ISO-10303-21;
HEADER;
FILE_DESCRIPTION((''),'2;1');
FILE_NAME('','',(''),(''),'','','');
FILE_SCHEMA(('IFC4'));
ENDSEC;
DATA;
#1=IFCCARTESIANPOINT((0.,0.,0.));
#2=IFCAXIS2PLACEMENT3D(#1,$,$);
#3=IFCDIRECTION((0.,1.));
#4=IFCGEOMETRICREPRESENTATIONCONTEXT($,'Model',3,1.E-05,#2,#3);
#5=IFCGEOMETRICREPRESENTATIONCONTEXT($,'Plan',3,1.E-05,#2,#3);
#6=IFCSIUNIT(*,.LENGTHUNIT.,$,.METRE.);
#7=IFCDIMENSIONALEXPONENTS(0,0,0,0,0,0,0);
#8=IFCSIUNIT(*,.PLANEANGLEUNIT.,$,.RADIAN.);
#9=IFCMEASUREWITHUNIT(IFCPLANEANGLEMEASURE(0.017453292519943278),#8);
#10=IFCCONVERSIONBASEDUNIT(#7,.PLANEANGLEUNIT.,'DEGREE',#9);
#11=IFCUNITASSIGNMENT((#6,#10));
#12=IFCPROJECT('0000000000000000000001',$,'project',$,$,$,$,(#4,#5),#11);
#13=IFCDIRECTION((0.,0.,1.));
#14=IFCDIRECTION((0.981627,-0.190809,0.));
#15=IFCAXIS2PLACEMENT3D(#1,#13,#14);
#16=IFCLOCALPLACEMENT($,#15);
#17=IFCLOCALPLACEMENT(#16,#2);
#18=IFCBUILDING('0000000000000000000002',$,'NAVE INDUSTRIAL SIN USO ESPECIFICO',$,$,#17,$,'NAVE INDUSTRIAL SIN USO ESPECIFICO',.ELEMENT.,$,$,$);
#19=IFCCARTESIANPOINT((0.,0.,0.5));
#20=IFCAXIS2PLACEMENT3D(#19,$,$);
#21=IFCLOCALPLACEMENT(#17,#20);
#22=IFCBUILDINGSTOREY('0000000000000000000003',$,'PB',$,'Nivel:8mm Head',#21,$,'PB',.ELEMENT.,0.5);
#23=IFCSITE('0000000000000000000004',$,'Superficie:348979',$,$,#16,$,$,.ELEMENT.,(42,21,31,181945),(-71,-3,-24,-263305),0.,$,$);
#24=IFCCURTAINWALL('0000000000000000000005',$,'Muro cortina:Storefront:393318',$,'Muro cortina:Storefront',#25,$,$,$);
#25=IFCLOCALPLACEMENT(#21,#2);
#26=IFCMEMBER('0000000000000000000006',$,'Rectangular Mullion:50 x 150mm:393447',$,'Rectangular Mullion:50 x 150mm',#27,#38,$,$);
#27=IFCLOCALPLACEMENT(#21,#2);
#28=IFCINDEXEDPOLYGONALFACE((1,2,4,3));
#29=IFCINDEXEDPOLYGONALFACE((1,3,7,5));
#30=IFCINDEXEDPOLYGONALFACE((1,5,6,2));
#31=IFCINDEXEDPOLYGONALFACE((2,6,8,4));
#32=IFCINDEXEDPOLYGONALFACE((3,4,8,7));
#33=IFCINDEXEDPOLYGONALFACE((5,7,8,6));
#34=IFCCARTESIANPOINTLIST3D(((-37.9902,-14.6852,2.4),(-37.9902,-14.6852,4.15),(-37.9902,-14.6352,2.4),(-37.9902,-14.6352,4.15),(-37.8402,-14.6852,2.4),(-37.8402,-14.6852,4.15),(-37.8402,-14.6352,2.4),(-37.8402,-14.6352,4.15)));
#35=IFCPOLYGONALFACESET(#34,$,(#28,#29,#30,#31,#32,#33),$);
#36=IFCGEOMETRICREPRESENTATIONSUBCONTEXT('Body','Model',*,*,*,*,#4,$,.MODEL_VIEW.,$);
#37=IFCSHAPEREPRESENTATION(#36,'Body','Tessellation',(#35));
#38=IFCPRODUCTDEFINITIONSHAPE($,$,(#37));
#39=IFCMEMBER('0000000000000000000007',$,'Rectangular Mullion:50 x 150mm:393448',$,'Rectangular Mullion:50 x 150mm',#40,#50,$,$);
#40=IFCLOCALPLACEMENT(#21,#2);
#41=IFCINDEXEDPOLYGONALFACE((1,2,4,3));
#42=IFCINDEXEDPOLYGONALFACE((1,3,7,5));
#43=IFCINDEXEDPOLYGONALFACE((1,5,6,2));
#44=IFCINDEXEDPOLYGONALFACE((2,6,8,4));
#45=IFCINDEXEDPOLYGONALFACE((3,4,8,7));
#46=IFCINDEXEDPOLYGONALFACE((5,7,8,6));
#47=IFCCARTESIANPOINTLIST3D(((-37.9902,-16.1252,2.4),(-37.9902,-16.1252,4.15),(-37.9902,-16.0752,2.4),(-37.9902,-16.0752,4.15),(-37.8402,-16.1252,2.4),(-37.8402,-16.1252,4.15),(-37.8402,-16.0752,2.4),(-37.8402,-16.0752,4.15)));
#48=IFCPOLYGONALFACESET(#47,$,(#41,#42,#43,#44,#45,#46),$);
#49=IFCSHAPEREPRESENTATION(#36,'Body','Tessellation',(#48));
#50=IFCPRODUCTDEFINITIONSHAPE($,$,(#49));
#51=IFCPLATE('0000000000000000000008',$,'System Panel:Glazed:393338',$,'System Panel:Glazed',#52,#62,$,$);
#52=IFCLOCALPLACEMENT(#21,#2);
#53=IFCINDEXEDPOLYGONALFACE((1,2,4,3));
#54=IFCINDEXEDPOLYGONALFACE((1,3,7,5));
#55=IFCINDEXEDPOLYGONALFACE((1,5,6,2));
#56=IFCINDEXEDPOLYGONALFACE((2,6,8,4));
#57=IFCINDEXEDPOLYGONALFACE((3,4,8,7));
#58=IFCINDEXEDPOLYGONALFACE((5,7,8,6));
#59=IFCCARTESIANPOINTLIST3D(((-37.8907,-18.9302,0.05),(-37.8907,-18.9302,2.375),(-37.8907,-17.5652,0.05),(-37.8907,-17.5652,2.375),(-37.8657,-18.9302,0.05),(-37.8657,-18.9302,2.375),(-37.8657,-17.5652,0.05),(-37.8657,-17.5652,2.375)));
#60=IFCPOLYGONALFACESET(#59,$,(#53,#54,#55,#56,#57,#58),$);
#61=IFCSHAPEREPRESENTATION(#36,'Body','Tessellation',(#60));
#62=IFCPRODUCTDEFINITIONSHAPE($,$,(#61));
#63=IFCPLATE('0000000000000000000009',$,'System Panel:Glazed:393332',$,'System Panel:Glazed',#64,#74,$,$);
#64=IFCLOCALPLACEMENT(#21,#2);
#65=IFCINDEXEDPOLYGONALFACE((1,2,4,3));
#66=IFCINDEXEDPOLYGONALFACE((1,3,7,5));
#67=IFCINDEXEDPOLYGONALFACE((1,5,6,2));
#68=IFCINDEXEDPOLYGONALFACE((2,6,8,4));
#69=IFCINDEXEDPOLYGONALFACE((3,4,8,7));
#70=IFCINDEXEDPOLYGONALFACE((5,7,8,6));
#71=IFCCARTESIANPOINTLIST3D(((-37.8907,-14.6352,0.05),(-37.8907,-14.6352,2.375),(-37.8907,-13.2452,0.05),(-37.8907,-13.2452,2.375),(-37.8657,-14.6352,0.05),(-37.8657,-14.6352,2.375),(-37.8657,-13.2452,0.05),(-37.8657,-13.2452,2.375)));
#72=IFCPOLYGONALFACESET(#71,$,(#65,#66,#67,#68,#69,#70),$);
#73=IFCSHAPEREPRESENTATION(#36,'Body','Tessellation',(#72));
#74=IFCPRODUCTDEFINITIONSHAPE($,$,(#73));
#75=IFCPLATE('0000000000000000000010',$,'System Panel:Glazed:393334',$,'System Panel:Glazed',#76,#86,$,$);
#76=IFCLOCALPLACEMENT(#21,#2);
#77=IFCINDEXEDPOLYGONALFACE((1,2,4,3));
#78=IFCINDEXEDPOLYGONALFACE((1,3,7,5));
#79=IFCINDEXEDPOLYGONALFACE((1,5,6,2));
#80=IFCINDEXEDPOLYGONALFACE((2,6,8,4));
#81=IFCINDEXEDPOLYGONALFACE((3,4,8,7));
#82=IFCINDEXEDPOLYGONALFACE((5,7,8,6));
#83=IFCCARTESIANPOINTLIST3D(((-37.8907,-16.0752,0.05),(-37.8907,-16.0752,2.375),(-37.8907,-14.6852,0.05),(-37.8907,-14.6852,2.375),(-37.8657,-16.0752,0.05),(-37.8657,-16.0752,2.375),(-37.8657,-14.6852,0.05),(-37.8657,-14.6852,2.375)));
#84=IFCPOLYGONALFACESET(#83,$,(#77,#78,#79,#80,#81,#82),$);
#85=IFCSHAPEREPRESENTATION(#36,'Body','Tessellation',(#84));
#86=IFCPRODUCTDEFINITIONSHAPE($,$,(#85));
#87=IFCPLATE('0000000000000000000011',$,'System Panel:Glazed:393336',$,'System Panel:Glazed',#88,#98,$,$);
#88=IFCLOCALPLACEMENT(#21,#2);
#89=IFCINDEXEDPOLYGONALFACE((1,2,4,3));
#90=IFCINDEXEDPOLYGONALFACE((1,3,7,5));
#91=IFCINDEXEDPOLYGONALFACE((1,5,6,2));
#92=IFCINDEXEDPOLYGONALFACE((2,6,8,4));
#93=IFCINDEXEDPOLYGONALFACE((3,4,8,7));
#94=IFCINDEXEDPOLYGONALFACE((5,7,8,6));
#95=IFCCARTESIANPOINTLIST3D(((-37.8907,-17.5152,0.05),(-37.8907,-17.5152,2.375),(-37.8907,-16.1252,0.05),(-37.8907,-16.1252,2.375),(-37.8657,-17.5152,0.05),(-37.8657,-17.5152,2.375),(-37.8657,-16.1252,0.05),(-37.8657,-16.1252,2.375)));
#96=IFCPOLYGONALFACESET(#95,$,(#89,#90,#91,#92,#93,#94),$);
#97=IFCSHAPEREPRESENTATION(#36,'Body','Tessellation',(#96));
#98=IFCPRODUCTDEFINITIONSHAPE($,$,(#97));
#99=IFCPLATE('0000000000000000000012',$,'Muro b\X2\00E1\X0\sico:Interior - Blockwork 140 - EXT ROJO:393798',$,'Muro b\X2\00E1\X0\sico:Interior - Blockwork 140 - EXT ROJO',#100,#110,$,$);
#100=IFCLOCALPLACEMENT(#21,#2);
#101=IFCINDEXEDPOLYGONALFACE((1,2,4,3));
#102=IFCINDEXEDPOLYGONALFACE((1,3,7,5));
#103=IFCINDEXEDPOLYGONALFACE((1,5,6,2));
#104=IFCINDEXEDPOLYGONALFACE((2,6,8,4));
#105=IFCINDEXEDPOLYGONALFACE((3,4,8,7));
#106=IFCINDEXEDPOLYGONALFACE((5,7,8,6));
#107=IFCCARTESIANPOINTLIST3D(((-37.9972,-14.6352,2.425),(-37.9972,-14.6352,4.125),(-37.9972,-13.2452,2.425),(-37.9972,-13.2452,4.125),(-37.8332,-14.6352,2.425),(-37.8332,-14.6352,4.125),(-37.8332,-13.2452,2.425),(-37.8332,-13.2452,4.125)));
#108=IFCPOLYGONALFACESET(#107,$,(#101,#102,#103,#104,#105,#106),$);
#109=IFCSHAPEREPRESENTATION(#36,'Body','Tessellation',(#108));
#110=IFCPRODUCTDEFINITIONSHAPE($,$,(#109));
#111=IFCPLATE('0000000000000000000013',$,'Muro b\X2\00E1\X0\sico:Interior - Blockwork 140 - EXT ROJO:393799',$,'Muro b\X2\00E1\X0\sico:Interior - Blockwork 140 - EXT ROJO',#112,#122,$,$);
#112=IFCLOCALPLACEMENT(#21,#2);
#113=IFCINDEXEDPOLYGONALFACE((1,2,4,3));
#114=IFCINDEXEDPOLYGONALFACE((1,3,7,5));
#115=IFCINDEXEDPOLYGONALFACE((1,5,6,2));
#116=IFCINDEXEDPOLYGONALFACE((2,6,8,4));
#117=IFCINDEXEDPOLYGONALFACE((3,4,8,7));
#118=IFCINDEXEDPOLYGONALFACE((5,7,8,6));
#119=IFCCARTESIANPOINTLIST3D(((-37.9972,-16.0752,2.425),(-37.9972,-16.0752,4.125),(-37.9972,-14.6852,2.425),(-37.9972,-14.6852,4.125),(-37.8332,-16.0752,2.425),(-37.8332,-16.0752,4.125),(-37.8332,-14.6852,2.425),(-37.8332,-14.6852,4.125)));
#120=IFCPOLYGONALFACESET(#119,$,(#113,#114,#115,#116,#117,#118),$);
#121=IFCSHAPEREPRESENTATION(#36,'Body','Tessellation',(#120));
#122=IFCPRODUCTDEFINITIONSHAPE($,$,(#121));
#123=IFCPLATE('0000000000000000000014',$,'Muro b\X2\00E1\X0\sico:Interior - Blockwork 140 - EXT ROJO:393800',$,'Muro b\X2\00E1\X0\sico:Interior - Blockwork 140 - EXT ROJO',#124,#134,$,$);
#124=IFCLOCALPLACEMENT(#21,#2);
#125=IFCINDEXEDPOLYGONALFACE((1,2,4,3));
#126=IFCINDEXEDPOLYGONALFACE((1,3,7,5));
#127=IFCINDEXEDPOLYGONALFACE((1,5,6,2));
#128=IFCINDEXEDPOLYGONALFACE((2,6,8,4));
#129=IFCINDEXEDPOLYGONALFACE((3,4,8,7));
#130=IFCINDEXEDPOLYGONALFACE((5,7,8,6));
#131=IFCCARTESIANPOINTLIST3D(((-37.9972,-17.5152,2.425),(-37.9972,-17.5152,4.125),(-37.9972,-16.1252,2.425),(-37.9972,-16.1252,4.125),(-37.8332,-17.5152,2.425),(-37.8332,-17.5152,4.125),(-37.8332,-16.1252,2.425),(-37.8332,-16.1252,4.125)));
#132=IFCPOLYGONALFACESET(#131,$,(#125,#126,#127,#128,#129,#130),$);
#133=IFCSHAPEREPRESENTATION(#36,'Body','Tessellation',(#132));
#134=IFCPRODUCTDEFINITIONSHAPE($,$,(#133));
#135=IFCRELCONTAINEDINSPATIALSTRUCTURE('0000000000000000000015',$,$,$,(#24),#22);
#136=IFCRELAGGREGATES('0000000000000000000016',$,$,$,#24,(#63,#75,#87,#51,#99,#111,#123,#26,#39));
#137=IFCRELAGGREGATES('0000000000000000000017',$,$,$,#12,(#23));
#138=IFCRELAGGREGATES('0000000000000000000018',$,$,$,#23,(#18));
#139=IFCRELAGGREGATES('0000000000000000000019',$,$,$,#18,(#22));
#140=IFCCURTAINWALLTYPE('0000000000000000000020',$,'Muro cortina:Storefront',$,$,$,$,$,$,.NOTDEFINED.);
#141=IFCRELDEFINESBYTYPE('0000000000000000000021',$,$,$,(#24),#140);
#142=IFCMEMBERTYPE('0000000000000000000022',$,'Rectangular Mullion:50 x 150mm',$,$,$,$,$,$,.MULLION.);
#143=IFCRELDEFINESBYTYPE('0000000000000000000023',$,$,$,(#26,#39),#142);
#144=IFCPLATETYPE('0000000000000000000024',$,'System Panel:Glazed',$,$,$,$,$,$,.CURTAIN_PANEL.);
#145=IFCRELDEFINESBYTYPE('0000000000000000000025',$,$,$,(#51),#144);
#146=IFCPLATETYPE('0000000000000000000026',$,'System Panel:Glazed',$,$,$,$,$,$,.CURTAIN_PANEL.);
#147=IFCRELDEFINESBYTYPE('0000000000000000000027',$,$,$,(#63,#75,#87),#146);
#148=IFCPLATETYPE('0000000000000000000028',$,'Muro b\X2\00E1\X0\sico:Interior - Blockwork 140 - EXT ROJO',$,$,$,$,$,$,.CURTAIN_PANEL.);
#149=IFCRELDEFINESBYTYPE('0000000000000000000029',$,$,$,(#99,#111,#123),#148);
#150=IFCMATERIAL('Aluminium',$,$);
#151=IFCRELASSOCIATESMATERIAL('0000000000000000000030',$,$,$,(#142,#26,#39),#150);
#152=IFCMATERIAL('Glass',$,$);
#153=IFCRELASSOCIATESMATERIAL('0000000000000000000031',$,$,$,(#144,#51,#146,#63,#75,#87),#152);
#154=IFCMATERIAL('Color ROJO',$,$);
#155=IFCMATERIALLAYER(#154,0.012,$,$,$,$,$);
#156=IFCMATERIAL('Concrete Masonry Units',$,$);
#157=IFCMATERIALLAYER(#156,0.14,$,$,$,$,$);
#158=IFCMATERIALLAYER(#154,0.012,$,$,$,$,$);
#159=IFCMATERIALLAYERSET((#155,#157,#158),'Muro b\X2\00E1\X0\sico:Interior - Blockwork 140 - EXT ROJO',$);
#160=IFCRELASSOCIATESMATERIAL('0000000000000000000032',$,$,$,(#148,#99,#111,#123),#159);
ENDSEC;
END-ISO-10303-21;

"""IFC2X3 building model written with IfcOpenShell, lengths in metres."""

from ifc_helpers import new_model, entity, si_unit, converted_unit, direction, frame, frame_2d, origin, origin_2d_with_axis, place, context, subcontext, project, spatial, rectangle, extrude, source, transform, mapped, material, layer, layer_set, layer_usage, type_object, type_shapes, element, aggregate, save


model = new_model("IFC2X3")

# Units and contexts
model_context = context("Model", 3, precision=1e-05, world=origin(), true_north=direction((0.0, 1.0)))
plan_context = context("Plan", 3, precision=1e-05, world=origin(), true_north=direction((0.0, 1.0)))
body_context = subcontext(model_context, "Body", "Model", "MODEL_VIEW")
ifc_project = project(units=[si_unit("LENGTHUNIT", "METRE"), converted_unit("PLANEANGLEUNIT", "DEGREE", entity("IfcPlaneAngleMeasure", 0.017453292519943278), si_unit("PLANEANGLEUNIT", "RADIAN"), dimensions=[0, 0, 0, 0, 0, 0, 0])], contexts=[model_context, plan_context])

# Site, building, storey
site_placement = place(None, frame((0.0, 0.0, 0.0), z_axis=(0.0, 0.0, 1.0), x_axis=(0.981627, -0.190809, 0.0)))
site = spatial("IfcSite", under=ifc_project, at=site_placement, Name="Superficie:348979", CompositionType="ELEMENT", RefLatitude=(42, 21, 31, 181945), RefLongitude=(-71, -3, -24, -263305), RefElevation=0.0)
building_placement = place(site_placement, origin())
building = spatial("IfcBuilding", under=site, at=building_placement, Name="NAVE INDUSTRIAL SIN USO ESPECIFICO", LongName="NAVE INDUSTRIAL SIN USO ESPECIFICO", CompositionType="ELEMENT")
storey_placement = place(building_placement, frame((0.0, 0.0, 0.5)))
storey = spatial("IfcBuildingStorey", under=building, at=storey_placement, Name="PB", ObjectType="Nivel:8mm Head", LongName="PB", CompositionType="ELEMENT", Elevation=0.5)

# Curtain wall, members, plates
curtain_wall_type = type_object("IfcCurtainWallType", Name="Muro cortina:Storefront", PredefinedType="NOTDEFINED")
curtain_wall_placement = place(storey_placement, frame((0.0, 0.0, -0.5)))
curtain_wall = element("IfcCurtainWall", 1, at=curtain_wall_placement, inside=storey, type_object=curtain_wall_type, Name="Muro cortina:Storefront:393318", ObjectType="Muro cortina:Storefront")
ifc_material_1 = material(Name="Aluminium")
member_type_1 = type_object("IfcMemberType", Name="Rectangular Mullion:50 x 150mm", PredefinedType="MULLION", material=ifc_material_1)
shared_shape_1 = source(origin(), body_context, "Body", "SweptSolid", [
    extrude(rectangle(XDim=0.05, YDim=0.15, at=origin_2d_with_axis()), frame((0.0, 0.0, -1.75), z_axis=(0.0, 0.0, 1.0), x_axis=(-1.0, 0.0, 0.0)), (0.0, 0.0, 1.0), 1.75),
])
type_shapes(member_type_1, [shared_shape_1])
member_1_placement = place(curtain_wall_placement, frame((-37.9152, -14.6602, 2.9), z_axis=(0.0, 0.0, -1.0), x_axis=(0.0, -1.0, 0.0)))
member_1 = element("IfcMember", 2, at=member_1_placement, type_object=member_type_1, material=ifc_material_1, Name="Rectangular Mullion:50 x 150mm:393447", ObjectType="Rectangular Mullion:50 x 150mm", context=body_context, shape_type="MappedRepresentation", body=[
    mapped(shared_shape_1, transform((0.0, 0.0, 0.0), scale=1.0)),
])
member_2_placement = place(curtain_wall_placement, frame((-37.9152, -16.1002, 2.9), z_axis=(0.0, 0.0, -1.0), x_axis=(0.0, -1.0, 0.0)))
member_2 = element("IfcMember", 3, at=member_2_placement, type_object=member_type_1, material=ifc_material_1, Name="Rectangular Mullion:50 x 150mm:393448", ObjectType="Rectangular Mullion:50 x 150mm", context=body_context, shape_type="MappedRepresentation", body=[
    mapped(shared_shape_1, transform((0.0, 0.0, 0.0), scale=1.0)),
])
ifc_material_2 = material(Name="Glass")
plate_type_1 = type_object("IfcPlateType", Name="System Panel:Glazed", PredefinedType="CURTAIN_PANEL", material=ifc_material_2)
shared_shape_2 = source(origin(), body_context, "Body", "SweptSolid", [
    extrude(rectangle(XDim=0.025, YDim=1.365, at=origin_2d_with_axis()), frame((0.6825, 0.0125, 0.0), z_axis=(0.0, 0.0, 1.0), x_axis=(0.0, 1.0, 0.0)), (0.0, 0.0, 1.0), 2.325),
])
type_shapes(plate_type_1, [shared_shape_2])
plate_1_placement = place(curtain_wall_placement, frame((-37.8907, -17.5652, 0.55), z_axis=(0.0, 0.0, 1.0), x_axis=(0.0, -1.0, 0.0)))
plate_1 = element("IfcPlate", 4, at=plate_1_placement, type_object=plate_type_1, material=ifc_material_2, Name="System Panel:Glazed:393338", ObjectType="System Panel:Glazed", context=body_context, shape_type="MappedRepresentation", body=[
    mapped(shared_shape_2, transform((0.0, 0.0, 0.0), scale=1.0)),
])
plate_type_2 = type_object("IfcPlateType", Name="System Panel:Glazed", PredefinedType="CURTAIN_PANEL", material=ifc_material_2)
shared_shape_3 = source(origin(), body_context, "Body", "SweptSolid", [
    extrude(rectangle(XDim=0.025, YDim=1.39, at=origin_2d_with_axis()), frame((0.695, 0.0125, 0.0), z_axis=(0.0, 0.0, 1.0), x_axis=(0.0, 1.0, 0.0)), (0.0, 0.0, 1.0), 2.325),
])
type_shapes(plate_type_2, [shared_shape_3])
plate_2_placement = place(curtain_wall_placement, frame((-37.8907, -13.2452, 0.55), z_axis=(0.0, 0.0, 1.0), x_axis=(0.0, -1.0, 0.0)))
plate_2 = element("IfcPlate", 5, at=plate_2_placement, type_object=plate_type_2, material=ifc_material_2, Name="System Panel:Glazed:393332", ObjectType="System Panel:Glazed", context=body_context, shape_type="MappedRepresentation", body=[
    mapped(shared_shape_3, transform((0.0, 0.0, 0.0), scale=1.0)),
])
plate_3_placement = place(curtain_wall_placement, frame((-37.8907, -14.6852, 0.55), z_axis=(0.0, 0.0, 1.0), x_axis=(0.0, -1.0, 0.0)))
plate_3 = element("IfcPlate", 6, at=plate_3_placement, type_object=plate_type_2, material=ifc_material_2, Name="System Panel:Glazed:393334", ObjectType="System Panel:Glazed", context=body_context, shape_type="MappedRepresentation", body=[
    mapped(shared_shape_3, transform((0.0, 0.0, 0.0), scale=1.0)),
])
plate_4_placement = place(curtain_wall_placement, frame((-37.8907, -16.1252, 0.55), z_axis=(0.0, 0.0, 1.0), x_axis=(0.0, -1.0, 0.0)))
plate_4 = element("IfcPlate", 7, at=plate_4_placement, type_object=plate_type_2, material=ifc_material_2, Name="System Panel:Glazed:393336", ObjectType="System Panel:Glazed", context=body_context, shape_type="MappedRepresentation", body=[
    mapped(shared_shape_3, transform((0.0, 0.0, 0.0), scale=1.0)),
])
ifc_material_3 = material(Name="Color ROJO")
ifc_layer_1 = layer(ifc_material_3, 0.012)
ifc_material_4 = material(Name="Concrete Masonry Units")
ifc_layer_2 = layer(ifc_material_4, 0.14)
ifc_layer_3 = layer(ifc_material_3, 0.012)
ifc_layer_set = layer_set([ifc_layer_1, ifc_layer_2, ifc_layer_3], Name="Muro básico:Interior - Blockwork 140 - EXT ROJO")
ifc_layer_usage_1 = layer_usage(ifc_layer_set, "AXIS2", "NEGATIVE", 0.082)
plate_type_3 = type_object("IfcPlateType", Name="Muro básico:Interior - Blockwork 140 - EXT ROJO", PredefinedType="CURTAIN_PANEL", material=ifc_layer_set)
plate_5_placement = place(storey_placement, frame((-37.9152, -13.2452, 2.425), z_axis=(0.0, 0.0, 1.0), x_axis=(0.0, -1.0, 0.0)))
plate_5 = element("IfcPlate", 8, at=plate_5_placement, type_object=plate_type_3, material=ifc_layer_usage_1, Name="Muro básico:Interior - Blockwork 140 - EXT ROJO:393798", ObjectType="Muro básico:Interior - Blockwork 140 - EXT ROJO", context=body_context, shape_type="SweptSolid", body=[
    extrude(rectangle(XDim=0.164, YDim=1.39, at=frame_2d((0.0, 0.0), x_axis=(1.0, 0.0))), frame((0.695, 0.0, 0.0), z_axis=(0.0, 0.0, 1.0), x_axis=(0.0, 1.0, 0.0)), (0.0, 0.0, 1.0), 1.7),
])
ifc_layer_usage_2 = layer_usage(ifc_layer_set, "AXIS2", "NEGATIVE", 0.082)
plate_6_placement = place(storey_placement, frame((-37.9152, -14.6852, 2.425), z_axis=(0.0, 0.0, 1.0), x_axis=(0.0, -1.0, 0.0)))
plate_6 = element("IfcPlate", 9, at=plate_6_placement, type_object=plate_type_3, material=ifc_layer_usage_2, Name="Muro básico:Interior - Blockwork 140 - EXT ROJO:393799", ObjectType="Muro básico:Interior - Blockwork 140 - EXT ROJO", context=body_context, shape_type="SweptSolid", body=[
    extrude(rectangle(XDim=0.164, YDim=1.39, at=frame_2d((0.0, 0.0), x_axis=(1.0, 0.0))), frame((0.695, 0.0, 0.0), z_axis=(0.0, 0.0, 1.0), x_axis=(0.0, 1.0, 0.0)), (0.0, 0.0, 1.0), 1.7),
])
ifc_layer_usage_3 = layer_usage(ifc_layer_set, "AXIS2", "NEGATIVE", 0.082)
plate_7_placement = place(storey_placement, frame((-37.9152, -16.1252, 2.425), z_axis=(0.0, 0.0, 1.0), x_axis=(0.0, -1.0, 0.0)))
plate_7 = element("IfcPlate", 10, at=plate_7_placement, type_object=plate_type_3, material=ifc_layer_usage_3, Name="Muro básico:Interior - Blockwork 140 - EXT ROJO:393800", ObjectType="Muro básico:Interior - Blockwork 140 - EXT ROJO", context=body_context, shape_type="SweptSolid", body=[
    extrude(rectangle(XDim=0.164, YDim=1.39, at=frame_2d((0.0, 0.0), x_axis=(1.0, 0.0))), frame((0.695, 0.0, 0.0), z_axis=(0.0, 0.0, 1.0), x_axis=(0.0, 1.0, 0.0)), (0.0, 0.0, 1.0), 1.7),
])
aggregate(curtain_wall, [plate_2, plate_3, plate_4, plate_1, plate_5, plate_6, plate_7, member_1, member_2])

save(model, "model.ifc")
